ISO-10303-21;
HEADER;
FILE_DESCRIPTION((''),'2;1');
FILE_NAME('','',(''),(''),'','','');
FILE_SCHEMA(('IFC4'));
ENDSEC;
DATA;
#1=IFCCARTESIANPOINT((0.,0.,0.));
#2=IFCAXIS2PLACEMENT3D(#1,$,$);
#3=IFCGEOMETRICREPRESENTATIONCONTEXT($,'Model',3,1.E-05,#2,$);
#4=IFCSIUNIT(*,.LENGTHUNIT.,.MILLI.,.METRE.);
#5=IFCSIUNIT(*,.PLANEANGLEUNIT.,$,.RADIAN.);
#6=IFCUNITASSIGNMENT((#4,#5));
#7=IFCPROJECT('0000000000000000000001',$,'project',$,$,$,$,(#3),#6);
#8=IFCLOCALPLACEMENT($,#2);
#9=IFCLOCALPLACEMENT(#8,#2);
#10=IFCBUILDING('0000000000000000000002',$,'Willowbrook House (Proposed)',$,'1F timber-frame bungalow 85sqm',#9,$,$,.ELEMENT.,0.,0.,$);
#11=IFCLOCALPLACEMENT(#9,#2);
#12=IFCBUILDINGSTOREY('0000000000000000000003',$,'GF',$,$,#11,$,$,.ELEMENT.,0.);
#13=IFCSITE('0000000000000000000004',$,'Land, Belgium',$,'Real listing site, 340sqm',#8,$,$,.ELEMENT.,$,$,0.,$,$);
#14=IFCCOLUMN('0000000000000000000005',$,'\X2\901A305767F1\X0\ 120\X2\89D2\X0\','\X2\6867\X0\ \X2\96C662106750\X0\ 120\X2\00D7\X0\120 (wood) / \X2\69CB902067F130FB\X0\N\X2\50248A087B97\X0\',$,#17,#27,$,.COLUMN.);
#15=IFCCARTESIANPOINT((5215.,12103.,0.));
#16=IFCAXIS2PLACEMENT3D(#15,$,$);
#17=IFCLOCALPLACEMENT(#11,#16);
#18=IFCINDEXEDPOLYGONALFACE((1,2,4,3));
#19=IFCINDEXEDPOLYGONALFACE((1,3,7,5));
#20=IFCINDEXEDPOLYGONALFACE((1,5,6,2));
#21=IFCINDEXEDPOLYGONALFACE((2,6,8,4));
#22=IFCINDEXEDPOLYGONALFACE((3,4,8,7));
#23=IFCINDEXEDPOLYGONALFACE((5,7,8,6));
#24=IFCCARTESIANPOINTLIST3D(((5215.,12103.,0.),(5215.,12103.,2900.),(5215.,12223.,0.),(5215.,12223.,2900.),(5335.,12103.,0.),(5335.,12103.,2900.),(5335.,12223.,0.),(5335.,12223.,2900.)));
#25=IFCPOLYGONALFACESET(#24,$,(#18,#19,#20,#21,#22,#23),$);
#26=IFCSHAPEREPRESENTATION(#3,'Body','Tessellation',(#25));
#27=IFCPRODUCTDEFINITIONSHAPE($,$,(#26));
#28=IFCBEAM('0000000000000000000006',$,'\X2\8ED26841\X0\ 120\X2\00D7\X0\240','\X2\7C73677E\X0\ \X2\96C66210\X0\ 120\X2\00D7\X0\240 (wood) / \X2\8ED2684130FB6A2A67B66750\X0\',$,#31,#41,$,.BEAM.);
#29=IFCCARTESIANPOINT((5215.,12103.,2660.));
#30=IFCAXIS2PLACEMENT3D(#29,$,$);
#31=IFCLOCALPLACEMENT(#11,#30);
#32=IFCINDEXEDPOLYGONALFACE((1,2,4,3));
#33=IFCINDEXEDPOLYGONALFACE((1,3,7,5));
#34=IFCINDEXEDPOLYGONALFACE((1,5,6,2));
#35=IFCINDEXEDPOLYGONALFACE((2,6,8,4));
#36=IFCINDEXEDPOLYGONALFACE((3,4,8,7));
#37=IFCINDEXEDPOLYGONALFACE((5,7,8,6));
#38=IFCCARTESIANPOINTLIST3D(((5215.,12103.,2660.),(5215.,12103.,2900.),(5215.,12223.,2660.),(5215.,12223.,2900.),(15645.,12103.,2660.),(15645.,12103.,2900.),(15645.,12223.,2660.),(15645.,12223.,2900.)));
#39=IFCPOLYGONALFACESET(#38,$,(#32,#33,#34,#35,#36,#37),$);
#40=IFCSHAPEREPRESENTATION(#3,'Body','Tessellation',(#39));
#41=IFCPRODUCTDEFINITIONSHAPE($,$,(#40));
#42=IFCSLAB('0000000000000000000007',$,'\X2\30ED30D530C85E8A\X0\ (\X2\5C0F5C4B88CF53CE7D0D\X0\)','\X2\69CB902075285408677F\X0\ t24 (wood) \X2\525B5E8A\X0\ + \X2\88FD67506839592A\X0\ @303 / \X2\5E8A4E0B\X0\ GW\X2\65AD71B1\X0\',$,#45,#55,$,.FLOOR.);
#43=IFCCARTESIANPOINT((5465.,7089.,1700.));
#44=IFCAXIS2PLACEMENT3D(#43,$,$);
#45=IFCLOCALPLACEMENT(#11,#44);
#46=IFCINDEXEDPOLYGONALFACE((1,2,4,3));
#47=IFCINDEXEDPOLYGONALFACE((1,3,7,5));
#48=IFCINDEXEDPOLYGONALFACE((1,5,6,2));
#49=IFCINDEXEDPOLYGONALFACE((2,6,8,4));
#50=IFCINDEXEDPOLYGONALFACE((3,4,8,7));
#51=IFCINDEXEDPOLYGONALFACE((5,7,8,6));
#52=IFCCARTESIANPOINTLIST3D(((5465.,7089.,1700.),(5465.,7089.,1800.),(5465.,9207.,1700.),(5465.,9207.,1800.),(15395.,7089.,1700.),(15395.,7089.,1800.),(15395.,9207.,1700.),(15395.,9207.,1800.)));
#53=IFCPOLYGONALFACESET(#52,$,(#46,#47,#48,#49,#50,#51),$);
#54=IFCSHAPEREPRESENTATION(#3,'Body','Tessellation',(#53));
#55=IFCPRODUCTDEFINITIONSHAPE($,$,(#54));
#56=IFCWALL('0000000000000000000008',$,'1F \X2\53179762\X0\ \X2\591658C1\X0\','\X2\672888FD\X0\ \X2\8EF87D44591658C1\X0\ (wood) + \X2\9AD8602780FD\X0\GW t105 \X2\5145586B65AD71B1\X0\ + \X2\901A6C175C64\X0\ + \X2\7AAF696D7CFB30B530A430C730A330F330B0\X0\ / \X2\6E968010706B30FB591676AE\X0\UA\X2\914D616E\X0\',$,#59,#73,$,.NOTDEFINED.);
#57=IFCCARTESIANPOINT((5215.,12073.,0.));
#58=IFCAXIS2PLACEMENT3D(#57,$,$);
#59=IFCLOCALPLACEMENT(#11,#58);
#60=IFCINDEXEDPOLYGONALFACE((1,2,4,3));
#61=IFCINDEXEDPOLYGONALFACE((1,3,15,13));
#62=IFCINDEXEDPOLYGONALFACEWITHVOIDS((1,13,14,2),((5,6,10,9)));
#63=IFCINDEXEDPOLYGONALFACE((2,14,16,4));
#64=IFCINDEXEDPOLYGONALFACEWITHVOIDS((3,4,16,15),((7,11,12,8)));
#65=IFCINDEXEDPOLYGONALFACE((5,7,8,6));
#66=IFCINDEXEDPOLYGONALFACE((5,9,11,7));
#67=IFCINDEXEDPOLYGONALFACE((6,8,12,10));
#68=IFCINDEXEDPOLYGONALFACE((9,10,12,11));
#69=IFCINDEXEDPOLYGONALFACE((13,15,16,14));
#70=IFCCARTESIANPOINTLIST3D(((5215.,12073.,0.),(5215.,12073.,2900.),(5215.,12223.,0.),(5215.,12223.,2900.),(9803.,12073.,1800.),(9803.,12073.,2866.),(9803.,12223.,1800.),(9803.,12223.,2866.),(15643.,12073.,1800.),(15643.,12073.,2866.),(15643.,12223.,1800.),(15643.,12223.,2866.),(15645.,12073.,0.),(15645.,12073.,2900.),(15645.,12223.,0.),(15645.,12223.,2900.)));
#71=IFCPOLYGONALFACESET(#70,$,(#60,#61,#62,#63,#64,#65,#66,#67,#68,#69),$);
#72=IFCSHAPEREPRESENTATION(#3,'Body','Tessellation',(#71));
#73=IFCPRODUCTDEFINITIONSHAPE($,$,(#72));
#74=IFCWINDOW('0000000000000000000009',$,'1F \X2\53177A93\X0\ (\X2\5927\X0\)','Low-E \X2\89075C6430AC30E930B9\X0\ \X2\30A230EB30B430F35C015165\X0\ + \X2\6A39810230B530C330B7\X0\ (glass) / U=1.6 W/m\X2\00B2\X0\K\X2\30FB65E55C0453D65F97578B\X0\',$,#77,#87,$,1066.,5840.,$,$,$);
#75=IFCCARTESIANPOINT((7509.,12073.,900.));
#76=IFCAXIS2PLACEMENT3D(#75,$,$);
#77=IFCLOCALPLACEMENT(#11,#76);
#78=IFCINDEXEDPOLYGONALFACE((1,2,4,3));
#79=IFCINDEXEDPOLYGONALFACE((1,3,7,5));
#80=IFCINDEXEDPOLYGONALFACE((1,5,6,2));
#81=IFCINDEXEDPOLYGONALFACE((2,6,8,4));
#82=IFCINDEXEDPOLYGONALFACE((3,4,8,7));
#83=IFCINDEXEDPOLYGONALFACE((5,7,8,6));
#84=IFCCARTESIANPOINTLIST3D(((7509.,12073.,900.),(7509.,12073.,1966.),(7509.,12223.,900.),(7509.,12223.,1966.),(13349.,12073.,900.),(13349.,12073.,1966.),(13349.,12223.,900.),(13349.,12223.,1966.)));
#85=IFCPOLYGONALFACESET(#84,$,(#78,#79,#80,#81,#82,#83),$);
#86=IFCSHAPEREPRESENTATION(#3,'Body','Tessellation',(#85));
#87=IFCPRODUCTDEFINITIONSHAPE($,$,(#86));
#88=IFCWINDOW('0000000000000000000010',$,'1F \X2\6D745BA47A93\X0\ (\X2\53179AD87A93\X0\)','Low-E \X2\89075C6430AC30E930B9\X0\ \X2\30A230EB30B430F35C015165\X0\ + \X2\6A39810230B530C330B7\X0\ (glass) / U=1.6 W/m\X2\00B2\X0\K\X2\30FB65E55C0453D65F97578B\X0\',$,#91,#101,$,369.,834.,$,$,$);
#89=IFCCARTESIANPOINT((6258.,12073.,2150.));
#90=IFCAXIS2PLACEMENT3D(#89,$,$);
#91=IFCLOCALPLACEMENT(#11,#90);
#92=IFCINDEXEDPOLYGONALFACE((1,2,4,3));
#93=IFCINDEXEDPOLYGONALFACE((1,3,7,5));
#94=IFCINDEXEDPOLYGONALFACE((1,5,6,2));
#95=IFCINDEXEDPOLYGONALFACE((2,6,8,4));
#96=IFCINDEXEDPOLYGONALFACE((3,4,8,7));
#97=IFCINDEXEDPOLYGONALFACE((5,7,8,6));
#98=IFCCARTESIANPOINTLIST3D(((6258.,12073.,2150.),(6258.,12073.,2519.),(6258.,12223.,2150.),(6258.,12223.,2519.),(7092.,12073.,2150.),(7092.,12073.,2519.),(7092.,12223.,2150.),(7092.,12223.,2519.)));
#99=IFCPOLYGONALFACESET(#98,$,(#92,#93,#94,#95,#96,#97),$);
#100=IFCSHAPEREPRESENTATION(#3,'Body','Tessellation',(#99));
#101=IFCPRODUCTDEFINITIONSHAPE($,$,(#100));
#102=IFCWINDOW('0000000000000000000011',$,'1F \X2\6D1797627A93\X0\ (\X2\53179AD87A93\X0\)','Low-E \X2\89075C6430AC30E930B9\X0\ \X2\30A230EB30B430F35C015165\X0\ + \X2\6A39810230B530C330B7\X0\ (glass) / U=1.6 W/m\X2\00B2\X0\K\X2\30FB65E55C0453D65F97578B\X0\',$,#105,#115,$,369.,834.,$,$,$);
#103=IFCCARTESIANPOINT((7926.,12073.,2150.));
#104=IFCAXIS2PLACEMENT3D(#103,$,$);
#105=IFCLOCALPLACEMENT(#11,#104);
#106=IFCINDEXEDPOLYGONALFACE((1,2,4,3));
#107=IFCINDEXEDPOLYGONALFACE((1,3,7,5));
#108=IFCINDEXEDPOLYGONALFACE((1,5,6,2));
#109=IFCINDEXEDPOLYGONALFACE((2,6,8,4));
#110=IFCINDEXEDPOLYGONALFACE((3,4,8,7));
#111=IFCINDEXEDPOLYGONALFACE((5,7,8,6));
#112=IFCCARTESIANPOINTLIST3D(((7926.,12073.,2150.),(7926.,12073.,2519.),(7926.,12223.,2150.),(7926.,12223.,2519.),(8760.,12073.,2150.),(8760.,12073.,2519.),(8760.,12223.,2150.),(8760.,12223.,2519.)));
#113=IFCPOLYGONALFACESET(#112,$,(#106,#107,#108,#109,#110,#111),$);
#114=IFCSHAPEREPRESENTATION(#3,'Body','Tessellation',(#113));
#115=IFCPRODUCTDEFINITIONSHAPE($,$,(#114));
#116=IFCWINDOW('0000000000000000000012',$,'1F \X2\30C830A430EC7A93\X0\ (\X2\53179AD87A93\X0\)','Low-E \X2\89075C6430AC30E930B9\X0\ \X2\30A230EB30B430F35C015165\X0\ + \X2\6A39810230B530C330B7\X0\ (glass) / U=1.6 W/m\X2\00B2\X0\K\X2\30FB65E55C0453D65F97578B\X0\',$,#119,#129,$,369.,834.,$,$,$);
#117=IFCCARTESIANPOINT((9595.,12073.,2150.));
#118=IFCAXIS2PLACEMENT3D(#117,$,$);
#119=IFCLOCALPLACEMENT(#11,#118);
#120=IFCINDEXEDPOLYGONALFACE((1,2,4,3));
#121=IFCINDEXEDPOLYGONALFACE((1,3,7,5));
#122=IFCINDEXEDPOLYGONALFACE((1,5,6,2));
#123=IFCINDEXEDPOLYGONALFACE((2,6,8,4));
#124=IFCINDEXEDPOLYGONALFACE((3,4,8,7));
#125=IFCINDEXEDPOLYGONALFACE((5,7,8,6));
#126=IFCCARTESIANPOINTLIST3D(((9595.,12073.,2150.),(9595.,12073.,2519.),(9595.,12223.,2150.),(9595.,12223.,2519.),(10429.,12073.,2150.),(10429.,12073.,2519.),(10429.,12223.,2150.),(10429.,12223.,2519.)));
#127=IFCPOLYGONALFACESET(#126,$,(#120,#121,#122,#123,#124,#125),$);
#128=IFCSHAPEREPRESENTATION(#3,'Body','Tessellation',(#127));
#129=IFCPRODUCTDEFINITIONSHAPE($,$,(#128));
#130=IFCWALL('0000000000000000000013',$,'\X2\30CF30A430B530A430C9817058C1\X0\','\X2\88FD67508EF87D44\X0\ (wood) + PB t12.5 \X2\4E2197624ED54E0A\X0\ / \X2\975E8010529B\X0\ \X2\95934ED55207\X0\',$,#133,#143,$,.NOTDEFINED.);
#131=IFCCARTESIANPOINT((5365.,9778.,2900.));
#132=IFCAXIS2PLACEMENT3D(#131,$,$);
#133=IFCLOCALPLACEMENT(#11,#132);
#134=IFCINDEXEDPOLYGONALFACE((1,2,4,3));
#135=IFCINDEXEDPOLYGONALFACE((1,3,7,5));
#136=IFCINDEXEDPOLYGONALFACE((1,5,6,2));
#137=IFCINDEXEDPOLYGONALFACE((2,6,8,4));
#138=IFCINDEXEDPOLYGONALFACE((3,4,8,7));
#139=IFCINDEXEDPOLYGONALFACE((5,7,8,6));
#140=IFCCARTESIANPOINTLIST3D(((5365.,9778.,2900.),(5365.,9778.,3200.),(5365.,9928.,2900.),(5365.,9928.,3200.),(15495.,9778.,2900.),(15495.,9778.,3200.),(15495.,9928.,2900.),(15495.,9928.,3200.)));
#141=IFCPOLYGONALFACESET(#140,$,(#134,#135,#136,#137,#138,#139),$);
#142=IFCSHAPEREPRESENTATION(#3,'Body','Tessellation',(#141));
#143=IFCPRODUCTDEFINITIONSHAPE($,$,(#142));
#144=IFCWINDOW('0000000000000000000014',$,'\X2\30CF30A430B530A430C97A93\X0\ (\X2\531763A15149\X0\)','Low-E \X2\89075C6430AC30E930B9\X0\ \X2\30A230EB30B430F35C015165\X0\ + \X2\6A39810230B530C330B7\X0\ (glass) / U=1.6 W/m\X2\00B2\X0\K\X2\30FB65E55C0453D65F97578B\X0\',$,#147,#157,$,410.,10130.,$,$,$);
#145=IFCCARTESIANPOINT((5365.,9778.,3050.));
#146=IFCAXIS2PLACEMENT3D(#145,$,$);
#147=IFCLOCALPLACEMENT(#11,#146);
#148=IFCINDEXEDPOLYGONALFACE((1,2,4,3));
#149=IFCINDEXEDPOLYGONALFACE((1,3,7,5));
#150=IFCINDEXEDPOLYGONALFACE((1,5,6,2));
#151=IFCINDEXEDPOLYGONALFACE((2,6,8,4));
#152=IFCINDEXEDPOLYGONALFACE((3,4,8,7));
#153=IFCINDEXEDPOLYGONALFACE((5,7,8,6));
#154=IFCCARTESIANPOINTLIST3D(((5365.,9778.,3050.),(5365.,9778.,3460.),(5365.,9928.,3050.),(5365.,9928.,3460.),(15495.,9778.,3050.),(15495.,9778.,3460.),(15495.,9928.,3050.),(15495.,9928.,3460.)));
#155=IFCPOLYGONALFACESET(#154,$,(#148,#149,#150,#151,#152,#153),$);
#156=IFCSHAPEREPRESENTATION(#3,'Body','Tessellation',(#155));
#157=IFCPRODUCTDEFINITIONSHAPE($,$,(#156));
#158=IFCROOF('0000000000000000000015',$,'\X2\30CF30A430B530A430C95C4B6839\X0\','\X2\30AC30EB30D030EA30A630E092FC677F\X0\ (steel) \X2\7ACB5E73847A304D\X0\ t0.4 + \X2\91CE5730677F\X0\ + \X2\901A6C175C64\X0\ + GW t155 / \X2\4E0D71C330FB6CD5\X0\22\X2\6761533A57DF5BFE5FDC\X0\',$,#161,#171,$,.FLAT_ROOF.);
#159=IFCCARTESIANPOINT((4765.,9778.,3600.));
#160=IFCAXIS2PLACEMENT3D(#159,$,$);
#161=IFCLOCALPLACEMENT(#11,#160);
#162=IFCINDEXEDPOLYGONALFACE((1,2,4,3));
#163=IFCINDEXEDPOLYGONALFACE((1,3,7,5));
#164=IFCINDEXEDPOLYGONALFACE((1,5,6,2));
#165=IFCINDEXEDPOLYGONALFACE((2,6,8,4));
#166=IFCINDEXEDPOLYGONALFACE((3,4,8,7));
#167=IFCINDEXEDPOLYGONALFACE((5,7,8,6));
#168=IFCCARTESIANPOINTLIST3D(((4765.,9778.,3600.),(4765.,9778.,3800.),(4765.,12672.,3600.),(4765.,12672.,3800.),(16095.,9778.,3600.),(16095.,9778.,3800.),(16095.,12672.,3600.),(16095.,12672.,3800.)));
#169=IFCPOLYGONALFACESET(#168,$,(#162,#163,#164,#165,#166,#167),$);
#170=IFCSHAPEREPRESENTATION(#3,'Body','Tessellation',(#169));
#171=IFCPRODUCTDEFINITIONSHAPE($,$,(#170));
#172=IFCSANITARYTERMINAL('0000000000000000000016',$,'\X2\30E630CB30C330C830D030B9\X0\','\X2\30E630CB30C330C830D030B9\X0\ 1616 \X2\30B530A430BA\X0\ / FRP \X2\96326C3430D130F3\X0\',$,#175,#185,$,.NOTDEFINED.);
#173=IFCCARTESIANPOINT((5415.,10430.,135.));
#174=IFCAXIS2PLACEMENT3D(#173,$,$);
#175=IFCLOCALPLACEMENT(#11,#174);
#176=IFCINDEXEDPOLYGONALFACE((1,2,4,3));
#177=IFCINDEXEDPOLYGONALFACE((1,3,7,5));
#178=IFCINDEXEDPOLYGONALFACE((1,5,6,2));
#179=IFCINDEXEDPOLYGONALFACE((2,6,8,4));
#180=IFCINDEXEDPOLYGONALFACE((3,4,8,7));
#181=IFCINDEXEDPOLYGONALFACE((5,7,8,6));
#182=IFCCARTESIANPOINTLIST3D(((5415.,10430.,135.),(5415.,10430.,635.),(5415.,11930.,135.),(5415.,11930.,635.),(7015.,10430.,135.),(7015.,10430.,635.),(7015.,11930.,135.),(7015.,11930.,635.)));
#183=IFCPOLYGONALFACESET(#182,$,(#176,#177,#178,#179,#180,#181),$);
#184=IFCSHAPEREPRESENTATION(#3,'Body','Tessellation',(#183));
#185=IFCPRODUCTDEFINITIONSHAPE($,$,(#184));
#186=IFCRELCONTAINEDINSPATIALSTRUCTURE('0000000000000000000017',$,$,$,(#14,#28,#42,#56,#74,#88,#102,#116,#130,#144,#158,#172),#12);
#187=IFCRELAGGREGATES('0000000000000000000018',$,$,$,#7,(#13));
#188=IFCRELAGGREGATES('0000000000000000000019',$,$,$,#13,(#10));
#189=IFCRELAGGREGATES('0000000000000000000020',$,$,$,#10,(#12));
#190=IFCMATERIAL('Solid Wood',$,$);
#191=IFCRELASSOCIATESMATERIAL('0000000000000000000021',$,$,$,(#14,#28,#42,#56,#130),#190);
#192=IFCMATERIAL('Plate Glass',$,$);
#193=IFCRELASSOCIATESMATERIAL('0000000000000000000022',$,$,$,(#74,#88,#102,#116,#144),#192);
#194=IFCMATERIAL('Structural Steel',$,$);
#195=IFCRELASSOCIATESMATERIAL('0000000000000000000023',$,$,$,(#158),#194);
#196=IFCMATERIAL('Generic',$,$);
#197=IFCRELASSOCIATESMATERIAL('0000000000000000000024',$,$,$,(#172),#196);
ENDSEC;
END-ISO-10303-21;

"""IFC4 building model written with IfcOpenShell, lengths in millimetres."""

from ifc_helpers import new_model, si_unit, frame, frame_2d, origin, place, context, project, spatial, rectangle, extrude, material, element, fill, save


model = new_model("IFC4")

# Units and contexts
model_context = context("Model", 3, precision=1e-05, world=origin())
ifc_project = project(units=[si_unit("LENGTHUNIT", "METRE", prefix="MILLI"), si_unit("PLANEANGLEUNIT", "RADIAN")], contexts=[model_context])

# Site, building, storey
site_placement = place(None, origin())
site = spatial("IfcSite", under=ifc_project, at=site_placement, Name="Land, Belgium", ObjectType="Real listing site, 340sqm", CompositionType="ELEMENT", RefElevation=0.0)
building_placement = place(site_placement, origin())
building = spatial("IfcBuilding", under=site, at=building_placement, Name="Willowbrook House (Proposed)", ObjectType="1F timber-frame bungalow 85sqm", CompositionType="ELEMENT", ElevationOfRefHeight=0.0, ElevationOfTerrain=0.0)
storey_placement = place(building_placement, origin())
storey = spatial("IfcBuildingStorey", under=building, at=storey_placement, Name="GF", CompositionType="ELEMENT", Elevation=0.0)

# Column
ifc_material_1 = material(Name="Solid Wood")
column_1_placement = place(storey_placement, frame((5215.0, 12103.0, 0.0)))
element("IfcColumn", 1, at=column_1_placement, inside=storey, material=ifc_material_1, Name="通し柱 120角", Description="桧 集成材 120×120 (wood) / 構造柱・N値計算", PredefinedType="COLUMN", context=model_context, shape_type="SweptSolid", body=[
    extrude(rectangle(XDim=120.0, YDim=120.0, at=frame_2d((60.0, 60.0))), frame((5215.0, 12103.0, 0.0)), (0.0, 0.0, 1.0), 2900.0),
])

# Beam
beam_1_placement = place(storey_placement, frame((5215.0, 12103.0, 2660.0)))
element("IfcBeam", 2, at=beam_1_placement, inside=storey, material=ifc_material_1, Name="軒桁 120×240", Description="米松 集成 120×240 (wood) / 軒桁・横架材", PredefinedType="BEAM", context=model_context, shape_type="SweptSolid", body=[
    extrude(rectangle(XDim=10430.0, YDim=120.0, at=frame_2d((5215.0, 60.0))), frame((5215.0, 12103.0, 2660.0)), (0.0, 0.0, 1.0), 240.0),
])

# Slab
slab_placement = place(storey_placement, frame((5465.0, 7089.0, 1700.0)))
element("IfcSlab", 3, at=slab_placement, inside=storey, material=ifc_material_1, Name="ロフト床 (小屋裏収納)", Description="構造用合板 t24 (wood) 剛床 + 製材根太 @303 / 床下 GW断熱", PredefinedType="FLOOR", context=model_context, shape_type="SweptSolid", body=[
    extrude(rectangle(XDim=9930.0, YDim=2118.0, at=frame_2d((4965.0, 1059.0))), frame((5465.0, 7089.0, 1700.0)), (0.0, 0.0, 1.0), 100.0),
])

# Wall, openings, windows
wall_1_placement = place(storey_placement, frame((5215.0, 12073.0, 0.0)))
wall_1 = element("IfcWall", 4, at=wall_1_placement, inside=storey, material=ifc_material_1, Name="1F 北面 外壁", Description="木製 軸組外壁 (wood) + 高性能GW t105 充填断熱 + 通気層 + 窯業系サイディング / 準耐火・外皮UA配慮", PredefinedType="NOTDEFINED", context=model_context, shape_type="SweptSolid", body=[
    extrude(rectangle(XDim=10430.0, YDim=150.0, at=frame_2d((5215.0, 75.0))), frame((5215.0, 12073.0, 0.0)), (0.0, 0.0, 1.0), 2900.0),
])
opening_1_placement = place(storey_placement, frame((7509.0, 12073.0, 900.0)))
opening_1 = element("IfcOpeningElement", 5, at=opening_1_placement, cuts=wall_1, PredefinedType="NOTDEFINED", context=model_context, shape_type="SweptSolid", body=[
    extrude(rectangle(XDim=5840.0, YDim=150.0, at=frame_2d((2920.0, 75.0))), frame((7509.0, 12073.0, 900.0)), (0.0, 0.0, 1.0), 1066.0),
])
opening_2_placement = place(storey_placement, frame((6258.0, 12073.0, 2150.0)))
opening_2 = element("IfcOpeningElement", 6, at=opening_2_placement, cuts=wall_1, PredefinedType="NOTDEFINED", context=model_context, shape_type="SweptSolid", body=[
    extrude(rectangle(XDim=834.0, YDim=150.0, at=frame_2d((417.0, 75.0))), frame((6258.0, 12073.0, 2150.0)), (0.0, 0.0, 1.0), 369.0),
])
opening_3_placement = place(storey_placement, frame((7926.0, 12073.0, 2150.0)))
opening_3 = element("IfcOpeningElement", 7, at=opening_3_placement, cuts=wall_1, PredefinedType="NOTDEFINED", context=model_context, shape_type="SweptSolid", body=[
    extrude(rectangle(XDim=834.0, YDim=150.0, at=frame_2d((417.0, 75.0))), frame((7926.0, 12073.0, 2150.0)), (0.0, 0.0, 1.0), 369.0),
])
opening_4_placement = place(storey_placement, frame((9595.0, 12073.0, 2150.0)))
opening_4 = element("IfcOpeningElement", 8, at=opening_4_placement, cuts=wall_1, PredefinedType="NOTDEFINED", context=model_context, shape_type="SweptSolid", body=[
    extrude(rectangle(XDim=834.0, YDim=150.0, at=frame_2d((417.0, 75.0))), frame((9595.0, 12073.0, 2150.0)), (0.0, 0.0, 1.0), 369.0),
])
ifc_material_2 = material(Name="Plate Glass")
window_1_placement = place(storey_placement, frame((7509.0, 12073.0, 900.0)))
window_1 = element("IfcWindow", 9, at=window_1_placement, inside=storey, material=ifc_material_2, Name="1F 北窓 (大)", Description="Low-E 複層ガラス アルゴン封入 + 樹脂サッシ (glass) / U=1.6 W/m²K・日射取得型", OverallHeight=1066.0, OverallWidth=5840.0, context=model_context, shape_type="SweptSolid", body=[
    extrude(rectangle(XDim=5840.0, YDim=150.0, at=frame_2d((2920.0, 75.0))), frame((7509.0, 12073.0, 900.0)), (0.0, 0.0, 1.0), 1066.0),
])
fill(opening_1, window_1)
window_2_placement = place(storey_placement, frame((6258.0, 12073.0, 2150.0)))
window_2 = element("IfcWindow", 10, at=window_2_placement, inside=storey, material=ifc_material_2, Name="1F 浴室窓 (北高窓)", Description="Low-E 複層ガラス アルゴン封入 + 樹脂サッシ (glass) / U=1.6 W/m²K・日射取得型", OverallHeight=369.0, OverallWidth=834.0, context=model_context, shape_type="SweptSolid", body=[
    extrude(rectangle(XDim=834.0, YDim=150.0, at=frame_2d((417.0, 75.0))), frame((6258.0, 12073.0, 2150.0)), (0.0, 0.0, 1.0), 369.0),
])
fill(opening_2, window_2)
window_3_placement = place(storey_placement, frame((7926.0, 12073.0, 2150.0)))
window_3 = element("IfcWindow", 11, at=window_3_placement, inside=storey, material=ifc_material_2, Name="1F 洗面窓 (北高窓)", Description="Low-E 複層ガラス アルゴン封入 + 樹脂サッシ (glass) / U=1.6 W/m²K・日射取得型", OverallHeight=369.0, OverallWidth=834.0, context=model_context, shape_type="SweptSolid", body=[
    extrude(rectangle(XDim=834.0, YDim=150.0, at=frame_2d((417.0, 75.0))), frame((7926.0, 12073.0, 2150.0)), (0.0, 0.0, 1.0), 369.0),
])
fill(opening_3, window_3)
window_4_placement = place(storey_placement, frame((9595.0, 12073.0, 2150.0)))
window_4 = element("IfcWindow", 12, at=window_4_placement, inside=storey, material=ifc_material_2, Name="1F トイレ窓 (北高窓)", Description="Low-E 複層ガラス アルゴン封入 + 樹脂サッシ (glass) / U=1.6 W/m²K・日射取得型", OverallHeight=369.0, OverallWidth=834.0, context=model_context, shape_type="SweptSolid", body=[
    extrude(rectangle(XDim=834.0, YDim=150.0, at=frame_2d((417.0, 75.0))), frame((9595.0, 12073.0, 2150.0)), (0.0, 0.0, 1.0), 369.0),
])
fill(opening_4, window_4)

# Wall, opening, window
wall_2_placement = place(storey_placement, frame((5365.0, 9778.0, 2900.0)))
wall_2 = element("IfcWall", 13, at=wall_2_placement, inside=storey, material=ifc_material_1, Name="ハイサイド腰壁", Description="製材軸組 (wood) + PB t12.5 両面仕上 / 非耐力 間仕切", PredefinedType="NOTDEFINED", context=model_context, shape_type="SweptSolid", body=[
    extrude(rectangle(XDim=10130.0, YDim=150.0, at=frame_2d((5065.0, 75.0))), frame((5365.0, 9778.0, 2900.0)), (0.0, 0.0, 1.0), 700.0),
])
opening_5_placement = place(storey_placement, frame((5365.0, 9778.0, 3050.0)))
opening_5 = element("IfcOpeningElement", 14, at=opening_5_placement, cuts=wall_2, PredefinedType="NOTDEFINED", context=model_context, shape_type="SweptSolid", body=[
    extrude(rectangle(XDim=10130.0, YDim=150.0, at=frame_2d((5065.0, 75.0))), frame((5365.0, 9778.0, 3050.0)), (0.0, 0.0, 1.0), 410.0),
])
window_5_placement = place(storey_placement, frame((5365.0, 9778.0, 3050.0)))
window_5 = element("IfcWindow", 15, at=window_5_placement, inside=storey, material=ifc_material_2, Name="ハイサイド窓 (北採光)", Description="Low-E 複層ガラス アルゴン封入 + 樹脂サッシ (glass) / U=1.6 W/m²K・日射取得型", OverallHeight=410.0, OverallWidth=10130.0, context=model_context, shape_type="SweptSolid", body=[
    extrude(rectangle(XDim=10130.0, YDim=150.0, at=frame_2d((5065.0, 75.0))), frame((5365.0, 9778.0, 3050.0)), (0.0, 0.0, 1.0), 410.0),
])
fill(opening_5, window_5)

# Roof
ifc_material_3 = material(Name="Structural Steel")
roof_placement = place(storey_placement, frame((4765.0, 9778.0, 3600.0)))
element("IfcRoof", 16, at=roof_placement, inside=storey, material=ifc_material_3, Name="ハイサイド屋根", Description="ガルバリウム鋼板 (steel) 立平葺き t0.4 + 野地板 + 通気層 + GW t155 / 不燃・法22条区域対応", PredefinedType="FLAT_ROOF", context=model_context, shape_type="SweptSolid", body=[
    extrude(rectangle(XDim=11330.0, YDim=2894.0, at=frame_2d((5665.0, 1447.0))), frame((4765.0, 9778.0, 3600.0)), (0.0, 0.0, 1.0), 200.0),
])

# Sanitary terminal
ifc_material_4 = material(Name="Generic")
sanitary_terminal_placement = place(storey_placement, frame((5415.0, 10430.0, 135.0)))
element("IfcSanitaryTerminal", 17, at=sanitary_terminal_placement, inside=storey, material=ifc_material_4, Name="ユニットバス", Description="ユニットバス 1616 サイズ / FRP 防水パン", PredefinedType="NOTDEFINED", context=model_context, shape_type="SweptSolid", body=[
    extrude(rectangle(XDim=1600.0, YDim=1500.0, at=frame_2d((800.0, 750.0))), frame((5415.0, 10430.0, 135.0)), (0.0, 0.0, 1.0), 500.0),
])

save(model, "model.ifc")
